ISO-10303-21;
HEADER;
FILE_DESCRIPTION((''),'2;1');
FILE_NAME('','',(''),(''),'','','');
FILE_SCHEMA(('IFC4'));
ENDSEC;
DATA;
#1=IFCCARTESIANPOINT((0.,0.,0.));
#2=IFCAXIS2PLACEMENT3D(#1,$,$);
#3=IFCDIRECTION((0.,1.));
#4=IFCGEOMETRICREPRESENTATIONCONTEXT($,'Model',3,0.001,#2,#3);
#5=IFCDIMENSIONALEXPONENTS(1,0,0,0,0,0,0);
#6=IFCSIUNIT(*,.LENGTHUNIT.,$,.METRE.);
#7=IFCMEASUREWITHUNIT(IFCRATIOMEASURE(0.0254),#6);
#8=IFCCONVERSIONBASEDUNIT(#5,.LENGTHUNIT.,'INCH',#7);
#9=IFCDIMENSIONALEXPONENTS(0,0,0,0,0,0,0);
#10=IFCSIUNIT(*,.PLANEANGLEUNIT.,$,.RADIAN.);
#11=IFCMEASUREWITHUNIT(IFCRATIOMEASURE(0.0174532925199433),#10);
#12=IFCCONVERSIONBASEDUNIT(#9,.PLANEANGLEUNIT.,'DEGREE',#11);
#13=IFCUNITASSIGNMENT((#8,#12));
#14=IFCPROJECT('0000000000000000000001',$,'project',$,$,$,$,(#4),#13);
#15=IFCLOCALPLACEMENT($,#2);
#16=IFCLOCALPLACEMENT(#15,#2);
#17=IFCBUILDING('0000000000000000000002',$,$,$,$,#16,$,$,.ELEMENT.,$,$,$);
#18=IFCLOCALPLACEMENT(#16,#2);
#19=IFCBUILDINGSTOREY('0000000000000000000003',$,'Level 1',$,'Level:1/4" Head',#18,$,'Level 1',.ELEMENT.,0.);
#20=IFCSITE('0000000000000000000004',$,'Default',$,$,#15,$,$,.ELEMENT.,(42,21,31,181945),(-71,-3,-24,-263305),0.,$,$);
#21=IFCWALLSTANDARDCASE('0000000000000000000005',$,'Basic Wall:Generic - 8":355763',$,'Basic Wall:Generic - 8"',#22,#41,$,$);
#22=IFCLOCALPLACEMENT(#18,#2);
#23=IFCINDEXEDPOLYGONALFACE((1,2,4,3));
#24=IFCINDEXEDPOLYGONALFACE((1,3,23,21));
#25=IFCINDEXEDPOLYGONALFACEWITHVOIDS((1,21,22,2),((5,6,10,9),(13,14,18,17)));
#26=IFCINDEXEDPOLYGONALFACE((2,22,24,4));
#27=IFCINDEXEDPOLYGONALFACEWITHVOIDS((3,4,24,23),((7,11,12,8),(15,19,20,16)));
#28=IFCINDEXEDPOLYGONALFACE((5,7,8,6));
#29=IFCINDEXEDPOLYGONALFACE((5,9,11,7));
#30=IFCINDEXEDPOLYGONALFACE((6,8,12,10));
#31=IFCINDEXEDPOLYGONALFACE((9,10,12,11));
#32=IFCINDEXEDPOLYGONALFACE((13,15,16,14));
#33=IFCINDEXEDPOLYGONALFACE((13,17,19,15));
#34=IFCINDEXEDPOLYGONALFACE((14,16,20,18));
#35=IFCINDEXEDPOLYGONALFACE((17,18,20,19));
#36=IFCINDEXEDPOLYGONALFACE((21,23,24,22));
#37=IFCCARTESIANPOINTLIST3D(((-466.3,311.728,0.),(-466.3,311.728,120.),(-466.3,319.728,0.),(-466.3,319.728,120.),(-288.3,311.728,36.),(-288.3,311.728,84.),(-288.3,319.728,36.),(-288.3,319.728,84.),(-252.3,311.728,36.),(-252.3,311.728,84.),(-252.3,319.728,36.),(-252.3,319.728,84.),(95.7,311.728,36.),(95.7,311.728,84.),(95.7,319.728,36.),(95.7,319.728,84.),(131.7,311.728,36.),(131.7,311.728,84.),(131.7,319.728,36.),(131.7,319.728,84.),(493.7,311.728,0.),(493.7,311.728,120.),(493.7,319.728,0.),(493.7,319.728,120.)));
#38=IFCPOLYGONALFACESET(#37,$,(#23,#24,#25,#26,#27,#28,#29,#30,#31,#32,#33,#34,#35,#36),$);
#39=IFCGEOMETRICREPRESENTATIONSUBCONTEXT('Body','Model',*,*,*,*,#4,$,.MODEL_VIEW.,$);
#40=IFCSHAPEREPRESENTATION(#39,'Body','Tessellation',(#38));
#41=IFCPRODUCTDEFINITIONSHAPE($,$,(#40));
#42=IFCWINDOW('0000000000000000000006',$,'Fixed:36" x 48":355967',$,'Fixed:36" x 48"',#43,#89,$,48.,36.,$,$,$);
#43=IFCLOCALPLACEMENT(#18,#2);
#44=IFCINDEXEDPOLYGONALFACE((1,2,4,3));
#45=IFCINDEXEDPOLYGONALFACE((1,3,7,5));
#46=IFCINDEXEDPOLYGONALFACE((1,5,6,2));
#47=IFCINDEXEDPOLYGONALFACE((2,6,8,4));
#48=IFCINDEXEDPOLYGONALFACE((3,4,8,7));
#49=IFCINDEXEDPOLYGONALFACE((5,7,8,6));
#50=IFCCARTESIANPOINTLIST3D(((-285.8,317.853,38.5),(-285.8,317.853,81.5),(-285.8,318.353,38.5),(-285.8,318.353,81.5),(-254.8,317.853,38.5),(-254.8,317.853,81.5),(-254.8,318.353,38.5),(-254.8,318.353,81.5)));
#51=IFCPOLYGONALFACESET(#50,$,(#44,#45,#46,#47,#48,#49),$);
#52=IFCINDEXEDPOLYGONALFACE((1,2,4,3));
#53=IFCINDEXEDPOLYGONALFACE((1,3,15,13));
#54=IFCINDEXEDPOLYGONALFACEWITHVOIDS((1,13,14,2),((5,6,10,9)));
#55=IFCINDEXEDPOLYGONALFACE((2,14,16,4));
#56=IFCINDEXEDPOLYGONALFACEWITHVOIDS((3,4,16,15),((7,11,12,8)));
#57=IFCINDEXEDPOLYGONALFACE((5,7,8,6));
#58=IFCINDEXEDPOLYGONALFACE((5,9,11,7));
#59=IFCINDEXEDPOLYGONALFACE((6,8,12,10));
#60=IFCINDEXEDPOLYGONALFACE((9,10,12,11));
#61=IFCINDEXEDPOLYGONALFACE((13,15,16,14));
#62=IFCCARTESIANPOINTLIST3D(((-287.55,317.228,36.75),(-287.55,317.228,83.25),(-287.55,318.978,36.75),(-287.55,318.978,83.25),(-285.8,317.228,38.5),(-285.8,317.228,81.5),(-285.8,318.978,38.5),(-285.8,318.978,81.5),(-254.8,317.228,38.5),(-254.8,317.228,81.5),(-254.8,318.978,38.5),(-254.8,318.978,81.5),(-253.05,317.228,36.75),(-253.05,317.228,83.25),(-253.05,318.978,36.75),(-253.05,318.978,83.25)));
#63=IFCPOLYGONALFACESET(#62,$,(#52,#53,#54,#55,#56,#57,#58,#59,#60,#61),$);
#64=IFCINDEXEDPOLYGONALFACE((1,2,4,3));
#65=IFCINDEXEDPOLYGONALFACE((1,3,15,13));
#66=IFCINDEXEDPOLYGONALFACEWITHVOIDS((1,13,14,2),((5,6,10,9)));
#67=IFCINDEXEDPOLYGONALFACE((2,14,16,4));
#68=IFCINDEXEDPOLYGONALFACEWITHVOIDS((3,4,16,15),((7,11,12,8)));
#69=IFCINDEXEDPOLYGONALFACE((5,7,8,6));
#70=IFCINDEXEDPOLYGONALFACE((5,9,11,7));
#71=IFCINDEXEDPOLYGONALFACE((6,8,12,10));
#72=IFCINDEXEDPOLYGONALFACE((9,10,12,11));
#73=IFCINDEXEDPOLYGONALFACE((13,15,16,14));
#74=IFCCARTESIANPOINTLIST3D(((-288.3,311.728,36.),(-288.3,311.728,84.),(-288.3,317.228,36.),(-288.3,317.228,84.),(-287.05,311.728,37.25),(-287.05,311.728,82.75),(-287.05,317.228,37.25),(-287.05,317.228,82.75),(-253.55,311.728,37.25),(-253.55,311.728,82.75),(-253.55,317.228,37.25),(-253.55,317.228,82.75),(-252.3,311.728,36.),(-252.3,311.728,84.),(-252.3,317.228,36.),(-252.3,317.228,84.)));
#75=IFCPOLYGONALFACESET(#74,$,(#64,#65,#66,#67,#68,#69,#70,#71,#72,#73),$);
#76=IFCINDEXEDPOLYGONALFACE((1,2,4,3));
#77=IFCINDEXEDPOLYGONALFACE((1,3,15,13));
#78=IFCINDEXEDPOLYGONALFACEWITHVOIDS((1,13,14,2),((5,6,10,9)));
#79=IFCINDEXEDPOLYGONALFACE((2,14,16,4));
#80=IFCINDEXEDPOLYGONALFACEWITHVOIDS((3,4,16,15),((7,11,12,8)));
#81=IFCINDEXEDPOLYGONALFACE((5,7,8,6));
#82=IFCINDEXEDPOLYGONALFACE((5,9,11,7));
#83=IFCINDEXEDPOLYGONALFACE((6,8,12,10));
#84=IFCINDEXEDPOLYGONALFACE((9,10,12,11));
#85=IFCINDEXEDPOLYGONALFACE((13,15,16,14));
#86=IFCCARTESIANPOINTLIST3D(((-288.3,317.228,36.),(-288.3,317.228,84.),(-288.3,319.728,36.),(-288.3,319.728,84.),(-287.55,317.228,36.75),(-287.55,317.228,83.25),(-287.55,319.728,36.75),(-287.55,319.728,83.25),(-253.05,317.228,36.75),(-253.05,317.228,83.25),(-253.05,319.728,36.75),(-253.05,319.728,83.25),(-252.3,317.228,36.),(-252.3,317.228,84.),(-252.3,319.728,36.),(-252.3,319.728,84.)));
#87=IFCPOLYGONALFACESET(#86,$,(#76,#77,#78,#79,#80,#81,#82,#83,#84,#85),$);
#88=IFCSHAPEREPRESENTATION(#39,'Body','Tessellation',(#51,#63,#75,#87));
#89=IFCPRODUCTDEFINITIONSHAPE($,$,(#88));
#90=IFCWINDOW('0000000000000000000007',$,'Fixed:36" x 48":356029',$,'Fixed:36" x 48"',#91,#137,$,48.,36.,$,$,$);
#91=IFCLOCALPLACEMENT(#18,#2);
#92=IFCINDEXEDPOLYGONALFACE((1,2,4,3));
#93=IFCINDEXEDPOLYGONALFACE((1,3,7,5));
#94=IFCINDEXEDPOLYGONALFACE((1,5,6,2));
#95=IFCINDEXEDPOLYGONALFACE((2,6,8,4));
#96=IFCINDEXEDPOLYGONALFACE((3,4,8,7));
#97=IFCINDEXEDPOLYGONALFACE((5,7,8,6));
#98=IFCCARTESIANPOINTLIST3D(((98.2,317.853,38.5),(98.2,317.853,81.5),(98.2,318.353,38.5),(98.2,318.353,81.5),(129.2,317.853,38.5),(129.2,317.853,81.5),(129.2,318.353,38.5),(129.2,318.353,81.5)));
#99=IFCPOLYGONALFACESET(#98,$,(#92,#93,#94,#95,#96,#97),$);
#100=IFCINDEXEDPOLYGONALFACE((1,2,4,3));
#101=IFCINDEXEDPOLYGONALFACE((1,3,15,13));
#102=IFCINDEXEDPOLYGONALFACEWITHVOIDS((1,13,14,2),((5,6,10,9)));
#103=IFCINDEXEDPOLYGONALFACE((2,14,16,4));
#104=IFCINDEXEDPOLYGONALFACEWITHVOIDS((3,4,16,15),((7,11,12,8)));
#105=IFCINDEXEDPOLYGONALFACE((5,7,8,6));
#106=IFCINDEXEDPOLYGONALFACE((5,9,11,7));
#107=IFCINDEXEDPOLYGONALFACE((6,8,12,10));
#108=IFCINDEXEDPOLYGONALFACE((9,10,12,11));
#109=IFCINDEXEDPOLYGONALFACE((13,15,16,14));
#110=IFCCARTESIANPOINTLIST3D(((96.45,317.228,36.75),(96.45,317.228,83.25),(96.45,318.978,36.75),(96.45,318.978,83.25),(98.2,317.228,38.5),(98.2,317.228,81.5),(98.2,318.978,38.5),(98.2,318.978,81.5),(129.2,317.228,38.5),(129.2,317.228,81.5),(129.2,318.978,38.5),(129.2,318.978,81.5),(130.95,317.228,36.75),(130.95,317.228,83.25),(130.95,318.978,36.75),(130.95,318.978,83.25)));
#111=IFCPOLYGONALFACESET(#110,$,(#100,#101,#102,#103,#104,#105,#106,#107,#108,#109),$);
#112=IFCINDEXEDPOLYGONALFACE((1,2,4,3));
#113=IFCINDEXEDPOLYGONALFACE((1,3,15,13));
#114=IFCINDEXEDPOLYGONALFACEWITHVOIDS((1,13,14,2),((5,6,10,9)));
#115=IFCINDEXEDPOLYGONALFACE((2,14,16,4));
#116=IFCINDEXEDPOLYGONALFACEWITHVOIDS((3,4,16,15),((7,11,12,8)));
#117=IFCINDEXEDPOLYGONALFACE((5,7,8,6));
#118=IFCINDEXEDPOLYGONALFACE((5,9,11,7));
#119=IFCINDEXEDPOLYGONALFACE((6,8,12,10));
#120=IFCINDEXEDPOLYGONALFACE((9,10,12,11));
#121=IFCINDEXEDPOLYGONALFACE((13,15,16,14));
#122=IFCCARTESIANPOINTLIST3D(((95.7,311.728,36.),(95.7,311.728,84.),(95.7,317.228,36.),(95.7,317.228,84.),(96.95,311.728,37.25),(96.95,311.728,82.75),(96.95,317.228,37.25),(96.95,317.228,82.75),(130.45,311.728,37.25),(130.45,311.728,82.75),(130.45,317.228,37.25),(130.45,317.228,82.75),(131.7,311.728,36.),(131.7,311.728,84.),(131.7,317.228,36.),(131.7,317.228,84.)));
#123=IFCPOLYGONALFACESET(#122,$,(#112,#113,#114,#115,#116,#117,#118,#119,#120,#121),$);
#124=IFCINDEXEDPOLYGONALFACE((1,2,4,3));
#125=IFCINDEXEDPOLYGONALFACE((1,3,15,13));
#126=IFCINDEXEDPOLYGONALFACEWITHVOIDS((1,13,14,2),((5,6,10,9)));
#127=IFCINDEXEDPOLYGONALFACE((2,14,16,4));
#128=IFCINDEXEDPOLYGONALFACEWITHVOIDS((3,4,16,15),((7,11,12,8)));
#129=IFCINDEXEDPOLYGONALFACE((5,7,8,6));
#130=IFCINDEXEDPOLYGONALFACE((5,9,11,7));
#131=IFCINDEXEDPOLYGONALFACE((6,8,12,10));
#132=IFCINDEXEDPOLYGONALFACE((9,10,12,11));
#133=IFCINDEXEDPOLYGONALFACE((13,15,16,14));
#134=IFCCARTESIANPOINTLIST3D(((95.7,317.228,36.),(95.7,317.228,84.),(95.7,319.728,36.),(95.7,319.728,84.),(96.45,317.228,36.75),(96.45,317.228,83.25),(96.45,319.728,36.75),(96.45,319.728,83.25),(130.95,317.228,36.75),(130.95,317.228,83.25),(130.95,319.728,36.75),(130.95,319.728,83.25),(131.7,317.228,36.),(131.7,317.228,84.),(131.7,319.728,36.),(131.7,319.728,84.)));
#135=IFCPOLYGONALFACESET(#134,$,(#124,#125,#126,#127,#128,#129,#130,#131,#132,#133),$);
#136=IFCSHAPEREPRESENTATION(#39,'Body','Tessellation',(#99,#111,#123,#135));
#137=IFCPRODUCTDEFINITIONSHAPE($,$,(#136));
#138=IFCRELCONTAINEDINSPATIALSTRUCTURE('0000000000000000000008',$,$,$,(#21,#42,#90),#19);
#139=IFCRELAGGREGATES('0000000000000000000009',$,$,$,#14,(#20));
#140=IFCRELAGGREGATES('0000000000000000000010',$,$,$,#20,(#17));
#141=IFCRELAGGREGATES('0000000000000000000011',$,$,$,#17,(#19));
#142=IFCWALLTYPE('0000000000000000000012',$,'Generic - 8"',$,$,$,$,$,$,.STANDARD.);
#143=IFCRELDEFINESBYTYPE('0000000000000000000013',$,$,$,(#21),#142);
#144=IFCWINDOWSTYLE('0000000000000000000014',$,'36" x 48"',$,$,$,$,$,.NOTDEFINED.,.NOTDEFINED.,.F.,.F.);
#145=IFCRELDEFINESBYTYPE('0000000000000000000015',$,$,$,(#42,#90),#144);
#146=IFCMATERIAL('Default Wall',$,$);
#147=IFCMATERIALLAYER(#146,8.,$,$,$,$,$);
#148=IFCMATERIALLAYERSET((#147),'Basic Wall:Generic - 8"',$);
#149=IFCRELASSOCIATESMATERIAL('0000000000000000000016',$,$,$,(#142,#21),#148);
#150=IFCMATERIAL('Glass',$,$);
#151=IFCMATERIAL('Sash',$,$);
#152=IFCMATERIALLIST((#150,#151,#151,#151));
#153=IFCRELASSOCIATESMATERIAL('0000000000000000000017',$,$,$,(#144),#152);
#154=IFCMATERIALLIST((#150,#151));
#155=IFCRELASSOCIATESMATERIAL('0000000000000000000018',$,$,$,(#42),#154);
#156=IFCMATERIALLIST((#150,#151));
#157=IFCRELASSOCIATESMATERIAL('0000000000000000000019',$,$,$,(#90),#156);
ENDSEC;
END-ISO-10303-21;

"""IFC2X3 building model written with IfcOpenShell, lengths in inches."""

from ifc_helpers import new_model, entity, si_unit, converted_unit, direction, frame, frame_2d, origin, place, context, subcontext, project, spatial, polyline, rectangle, outline, extrude, source, transform, mapped, material, material_list, layer, layer_set, layer_usage, type_object, type_shapes, element, fill, save


model = new_model("IFC2X3")

# Units and contexts
model_context = context("Model", 3, precision=0.001, world=origin(), true_north=direction((0.0, 1.0)))
body_context = subcontext(model_context, "Body", "Model", "MODEL_VIEW")
ifc_project = project(units=[converted_unit("LENGTHUNIT", "INCH", entity("IfcRatioMeasure", 0.0254), si_unit("LENGTHUNIT", "METRE"), dimensions=[1, 0, 0, 0, 0, 0, 0]), converted_unit("PLANEANGLEUNIT", "DEGREE", entity("IfcRatioMeasure", 0.0174532925199433), si_unit("PLANEANGLEUNIT", "RADIAN"), dimensions=[0, 0, 0, 0, 0, 0, 0])], contexts=[model_context])

# Site, building, storey
site_placement = place(None, origin())
site = spatial("IfcSite", under=ifc_project, at=site_placement, Name="Default", CompositionType="ELEMENT", RefLatitude=(42, 21, 31, 181945), RefLongitude=(-71, -3, -24, -263305), RefElevation=0.0)
building_placement = place(site_placement, origin())
building = spatial("IfcBuilding", under=site, at=building_placement, CompositionType="ELEMENT")
storey_placement = place(building_placement, origin())
storey = spatial("IfcBuildingStorey", under=building, at=storey_placement, Name="Level 1", ObjectType="Level:1/4\" Head", LongName="Level 1", CompositionType="ELEMENT", Elevation=0.0)

# Wall, openings, windows
ifc_material_1 = material(Name="Default Wall")
ifc_layer_1 = layer(ifc_material_1, 8.0)
ifc_layer_set_1 = layer_set([ifc_layer_1], Name="Basic Wall:Generic - 8\"")
ifc_layer_usage_1 = layer_usage(ifc_layer_set_1, "AXIS2", "NEGATIVE", 4.0)
wall_type_1 = type_object("IfcWallType", Name="Generic - 8\"", PredefinedType="STANDARD", material=ifc_layer_set_1)
wall_1_placement = place(storey_placement, frame((-466.3, 315.728, 0.0)))
wall_1 = element("IfcWallStandardCase", 1, at=wall_1_placement, inside=storey, type_object=wall_type_1, material=ifc_layer_usage_1, Name="Basic Wall:Generic - 8\":355763", ObjectType="Basic Wall:Generic - 8\"", context=body_context, shape_type="SweptSolid", body=[
    extrude(rectangle(XDim=960.0, YDim=8.0, at=frame_2d((480.0, 0.0), x_axis=(-1.0, 0.0))), origin(), (0.0, 0.0, 1.0), 120.0),
])
opening_1_placement = place(wall_1_placement, frame((214.0, 4.0, 36.0)))
opening_1 = element("IfcOpeningElement", 2, at=opening_1_placement, cuts=wall_1, ObjectType="Opening", context=body_context, shape_type="SweptSolid", body=[
    extrude(rectangle(XDim=48.0, YDim=36.0, at=frame_2d((24.0, 18.0), x_axis=(-1.0, 0.0))), frame((0.0, 0.0, 0.0), z_axis=(0.0, -1.0, 0.0), x_axis=(0.0, 0.0, 1.0)), (0.0, 0.0, 1.0), 8.0),
])
opening_2_placement = place(wall_1_placement, frame((598.0, 4.0, 36.0)))
opening_2 = element("IfcOpeningElement", 3, at=opening_2_placement, cuts=wall_1, ObjectType="Opening", context=body_context, shape_type="SweptSolid", body=[
    extrude(rectangle(XDim=48.0, YDim=36.0, at=frame_2d((24.0, 18.0), x_axis=(-1.0, 0.0))), frame((0.0, 0.0, 0.0), z_axis=(0.0, -1.0, 0.0), x_axis=(0.0, 0.0, 1.0)), (0.0, 0.0, 1.0), 8.0),
])
ifc_material_2 = material(Name="Glass")
ifc_material_3 = material(Name="Sash")
ifc_material_list_1 = material_list([ifc_material_2, ifc_material_3])
ifc_material_list_2 = material_list([ifc_material_2, ifc_material_3, ifc_material_3, ifc_material_3])
window_style = type_object("IfcWindowStyle", Name="36\" x 48\"", ConstructionType="NOTDEFINED", OperationType="NOTDEFINED", ParameterTakesPrecedence=False, Sizeable=False, material=ifc_material_list_2)
shared_shape_1 = source(origin(), body_context, "Body", "SweptSolid", [
    extrude(rectangle(XDim=0.5, YDim=31.0, at=frame_2d((0.0, 0.0), x_axis=(1.0, 0.0))), frame((18.0, 6.375, 2.5), z_axis=(0.0, 0.0, 1.0), x_axis=(0.0, 1.0, 0.0)), (0.0, 0.0, 1.0), 43.0),
    extrude(outline(polyline([(-17.25, -23.25), (17.25, -23.25), (17.25, 23.25), (-17.25, 23.25), (-17.25, -23.25)]), holes=[polyline([(-15.5, -21.5), (-15.5, 21.5), (15.5, 21.5), (15.5, -21.5), (-15.5, -21.5)])]), frame((18.0, 5.5, 24.0), z_axis=(0.0, 1.0, 0.0), x_axis=(1.0, 0.0, 0.0)), (0.0, 0.0, 1.0), 1.75),
    extrude(outline(polyline([(-18.0, -24.0), (18.0, -24.0), (18.0, 24.0), (-18.0, 24.0), (-18.0, -24.0)]), holes=[polyline([(-16.75, -22.75), (-16.75, 22.75), (16.75, 22.75), (16.75, -22.75), (-16.75, -22.75)])]), frame((18.0, 0.0, 24.0), z_axis=(0.0, 1.0, 0.0), x_axis=(1.0, 0.0, 0.0)), (0.0, 0.0, 1.0), 5.5),
    extrude(outline(polyline([(-24.0, -18.0), (24.0, -18.0), (24.0, 18.0), (-24.0, 18.0), (-24.0, -18.0)]), holes=[polyline([(-23.25, -17.25), (-23.25, 17.25), (23.25, 17.25), (23.25, -17.25), (-23.25, -17.25)])]), frame((18.0, 5.5, 24.0), z_axis=(0.0, 1.0, 0.0), x_axis=(0.0, 0.0, -1.0)), (0.0, 0.0, 1.0), 2.5),
])
type_shapes(window_style, [shared_shape_1])
window_1_placement = place(opening_1_placement, frame((-36.0, -8.0, 0.0)))
window_1 = element("IfcWindow", 4, at=window_1_placement, inside=storey, type_object=window_style, material=ifc_material_list_1, Name="Fixed:36\" x 48\":355967", ObjectType="Fixed:36\" x 48\"", OverallHeight=48.0, OverallWidth=36.0, context=body_context, shape_type="MappedRepresentation", body=[
    mapped(shared_shape_1, transform((0.0, 0.0, 0.0), scale=1.0)),
])
fill(opening_1, window_1)
ifc_material_list_3 = material_list([ifc_material_2, ifc_material_3])
window_2_placement = place(opening_2_placement, frame((-36.0, -8.0, 0.0)))
window_2 = element("IfcWindow", 5, at=window_2_placement, inside=storey, type_object=window_style, material=ifc_material_list_3, Name="Fixed:36\" x 48\":356029", ObjectType="Fixed:36\" x 48\"", OverallHeight=48.0, OverallWidth=36.0, context=body_context, shape_type="MappedRepresentation", body=[
    mapped(shared_shape_1, transform((0.0, 0.0, 0.0), scale=1.0)),
])
fill(opening_2, window_2)

save(model, "model.ifc")
